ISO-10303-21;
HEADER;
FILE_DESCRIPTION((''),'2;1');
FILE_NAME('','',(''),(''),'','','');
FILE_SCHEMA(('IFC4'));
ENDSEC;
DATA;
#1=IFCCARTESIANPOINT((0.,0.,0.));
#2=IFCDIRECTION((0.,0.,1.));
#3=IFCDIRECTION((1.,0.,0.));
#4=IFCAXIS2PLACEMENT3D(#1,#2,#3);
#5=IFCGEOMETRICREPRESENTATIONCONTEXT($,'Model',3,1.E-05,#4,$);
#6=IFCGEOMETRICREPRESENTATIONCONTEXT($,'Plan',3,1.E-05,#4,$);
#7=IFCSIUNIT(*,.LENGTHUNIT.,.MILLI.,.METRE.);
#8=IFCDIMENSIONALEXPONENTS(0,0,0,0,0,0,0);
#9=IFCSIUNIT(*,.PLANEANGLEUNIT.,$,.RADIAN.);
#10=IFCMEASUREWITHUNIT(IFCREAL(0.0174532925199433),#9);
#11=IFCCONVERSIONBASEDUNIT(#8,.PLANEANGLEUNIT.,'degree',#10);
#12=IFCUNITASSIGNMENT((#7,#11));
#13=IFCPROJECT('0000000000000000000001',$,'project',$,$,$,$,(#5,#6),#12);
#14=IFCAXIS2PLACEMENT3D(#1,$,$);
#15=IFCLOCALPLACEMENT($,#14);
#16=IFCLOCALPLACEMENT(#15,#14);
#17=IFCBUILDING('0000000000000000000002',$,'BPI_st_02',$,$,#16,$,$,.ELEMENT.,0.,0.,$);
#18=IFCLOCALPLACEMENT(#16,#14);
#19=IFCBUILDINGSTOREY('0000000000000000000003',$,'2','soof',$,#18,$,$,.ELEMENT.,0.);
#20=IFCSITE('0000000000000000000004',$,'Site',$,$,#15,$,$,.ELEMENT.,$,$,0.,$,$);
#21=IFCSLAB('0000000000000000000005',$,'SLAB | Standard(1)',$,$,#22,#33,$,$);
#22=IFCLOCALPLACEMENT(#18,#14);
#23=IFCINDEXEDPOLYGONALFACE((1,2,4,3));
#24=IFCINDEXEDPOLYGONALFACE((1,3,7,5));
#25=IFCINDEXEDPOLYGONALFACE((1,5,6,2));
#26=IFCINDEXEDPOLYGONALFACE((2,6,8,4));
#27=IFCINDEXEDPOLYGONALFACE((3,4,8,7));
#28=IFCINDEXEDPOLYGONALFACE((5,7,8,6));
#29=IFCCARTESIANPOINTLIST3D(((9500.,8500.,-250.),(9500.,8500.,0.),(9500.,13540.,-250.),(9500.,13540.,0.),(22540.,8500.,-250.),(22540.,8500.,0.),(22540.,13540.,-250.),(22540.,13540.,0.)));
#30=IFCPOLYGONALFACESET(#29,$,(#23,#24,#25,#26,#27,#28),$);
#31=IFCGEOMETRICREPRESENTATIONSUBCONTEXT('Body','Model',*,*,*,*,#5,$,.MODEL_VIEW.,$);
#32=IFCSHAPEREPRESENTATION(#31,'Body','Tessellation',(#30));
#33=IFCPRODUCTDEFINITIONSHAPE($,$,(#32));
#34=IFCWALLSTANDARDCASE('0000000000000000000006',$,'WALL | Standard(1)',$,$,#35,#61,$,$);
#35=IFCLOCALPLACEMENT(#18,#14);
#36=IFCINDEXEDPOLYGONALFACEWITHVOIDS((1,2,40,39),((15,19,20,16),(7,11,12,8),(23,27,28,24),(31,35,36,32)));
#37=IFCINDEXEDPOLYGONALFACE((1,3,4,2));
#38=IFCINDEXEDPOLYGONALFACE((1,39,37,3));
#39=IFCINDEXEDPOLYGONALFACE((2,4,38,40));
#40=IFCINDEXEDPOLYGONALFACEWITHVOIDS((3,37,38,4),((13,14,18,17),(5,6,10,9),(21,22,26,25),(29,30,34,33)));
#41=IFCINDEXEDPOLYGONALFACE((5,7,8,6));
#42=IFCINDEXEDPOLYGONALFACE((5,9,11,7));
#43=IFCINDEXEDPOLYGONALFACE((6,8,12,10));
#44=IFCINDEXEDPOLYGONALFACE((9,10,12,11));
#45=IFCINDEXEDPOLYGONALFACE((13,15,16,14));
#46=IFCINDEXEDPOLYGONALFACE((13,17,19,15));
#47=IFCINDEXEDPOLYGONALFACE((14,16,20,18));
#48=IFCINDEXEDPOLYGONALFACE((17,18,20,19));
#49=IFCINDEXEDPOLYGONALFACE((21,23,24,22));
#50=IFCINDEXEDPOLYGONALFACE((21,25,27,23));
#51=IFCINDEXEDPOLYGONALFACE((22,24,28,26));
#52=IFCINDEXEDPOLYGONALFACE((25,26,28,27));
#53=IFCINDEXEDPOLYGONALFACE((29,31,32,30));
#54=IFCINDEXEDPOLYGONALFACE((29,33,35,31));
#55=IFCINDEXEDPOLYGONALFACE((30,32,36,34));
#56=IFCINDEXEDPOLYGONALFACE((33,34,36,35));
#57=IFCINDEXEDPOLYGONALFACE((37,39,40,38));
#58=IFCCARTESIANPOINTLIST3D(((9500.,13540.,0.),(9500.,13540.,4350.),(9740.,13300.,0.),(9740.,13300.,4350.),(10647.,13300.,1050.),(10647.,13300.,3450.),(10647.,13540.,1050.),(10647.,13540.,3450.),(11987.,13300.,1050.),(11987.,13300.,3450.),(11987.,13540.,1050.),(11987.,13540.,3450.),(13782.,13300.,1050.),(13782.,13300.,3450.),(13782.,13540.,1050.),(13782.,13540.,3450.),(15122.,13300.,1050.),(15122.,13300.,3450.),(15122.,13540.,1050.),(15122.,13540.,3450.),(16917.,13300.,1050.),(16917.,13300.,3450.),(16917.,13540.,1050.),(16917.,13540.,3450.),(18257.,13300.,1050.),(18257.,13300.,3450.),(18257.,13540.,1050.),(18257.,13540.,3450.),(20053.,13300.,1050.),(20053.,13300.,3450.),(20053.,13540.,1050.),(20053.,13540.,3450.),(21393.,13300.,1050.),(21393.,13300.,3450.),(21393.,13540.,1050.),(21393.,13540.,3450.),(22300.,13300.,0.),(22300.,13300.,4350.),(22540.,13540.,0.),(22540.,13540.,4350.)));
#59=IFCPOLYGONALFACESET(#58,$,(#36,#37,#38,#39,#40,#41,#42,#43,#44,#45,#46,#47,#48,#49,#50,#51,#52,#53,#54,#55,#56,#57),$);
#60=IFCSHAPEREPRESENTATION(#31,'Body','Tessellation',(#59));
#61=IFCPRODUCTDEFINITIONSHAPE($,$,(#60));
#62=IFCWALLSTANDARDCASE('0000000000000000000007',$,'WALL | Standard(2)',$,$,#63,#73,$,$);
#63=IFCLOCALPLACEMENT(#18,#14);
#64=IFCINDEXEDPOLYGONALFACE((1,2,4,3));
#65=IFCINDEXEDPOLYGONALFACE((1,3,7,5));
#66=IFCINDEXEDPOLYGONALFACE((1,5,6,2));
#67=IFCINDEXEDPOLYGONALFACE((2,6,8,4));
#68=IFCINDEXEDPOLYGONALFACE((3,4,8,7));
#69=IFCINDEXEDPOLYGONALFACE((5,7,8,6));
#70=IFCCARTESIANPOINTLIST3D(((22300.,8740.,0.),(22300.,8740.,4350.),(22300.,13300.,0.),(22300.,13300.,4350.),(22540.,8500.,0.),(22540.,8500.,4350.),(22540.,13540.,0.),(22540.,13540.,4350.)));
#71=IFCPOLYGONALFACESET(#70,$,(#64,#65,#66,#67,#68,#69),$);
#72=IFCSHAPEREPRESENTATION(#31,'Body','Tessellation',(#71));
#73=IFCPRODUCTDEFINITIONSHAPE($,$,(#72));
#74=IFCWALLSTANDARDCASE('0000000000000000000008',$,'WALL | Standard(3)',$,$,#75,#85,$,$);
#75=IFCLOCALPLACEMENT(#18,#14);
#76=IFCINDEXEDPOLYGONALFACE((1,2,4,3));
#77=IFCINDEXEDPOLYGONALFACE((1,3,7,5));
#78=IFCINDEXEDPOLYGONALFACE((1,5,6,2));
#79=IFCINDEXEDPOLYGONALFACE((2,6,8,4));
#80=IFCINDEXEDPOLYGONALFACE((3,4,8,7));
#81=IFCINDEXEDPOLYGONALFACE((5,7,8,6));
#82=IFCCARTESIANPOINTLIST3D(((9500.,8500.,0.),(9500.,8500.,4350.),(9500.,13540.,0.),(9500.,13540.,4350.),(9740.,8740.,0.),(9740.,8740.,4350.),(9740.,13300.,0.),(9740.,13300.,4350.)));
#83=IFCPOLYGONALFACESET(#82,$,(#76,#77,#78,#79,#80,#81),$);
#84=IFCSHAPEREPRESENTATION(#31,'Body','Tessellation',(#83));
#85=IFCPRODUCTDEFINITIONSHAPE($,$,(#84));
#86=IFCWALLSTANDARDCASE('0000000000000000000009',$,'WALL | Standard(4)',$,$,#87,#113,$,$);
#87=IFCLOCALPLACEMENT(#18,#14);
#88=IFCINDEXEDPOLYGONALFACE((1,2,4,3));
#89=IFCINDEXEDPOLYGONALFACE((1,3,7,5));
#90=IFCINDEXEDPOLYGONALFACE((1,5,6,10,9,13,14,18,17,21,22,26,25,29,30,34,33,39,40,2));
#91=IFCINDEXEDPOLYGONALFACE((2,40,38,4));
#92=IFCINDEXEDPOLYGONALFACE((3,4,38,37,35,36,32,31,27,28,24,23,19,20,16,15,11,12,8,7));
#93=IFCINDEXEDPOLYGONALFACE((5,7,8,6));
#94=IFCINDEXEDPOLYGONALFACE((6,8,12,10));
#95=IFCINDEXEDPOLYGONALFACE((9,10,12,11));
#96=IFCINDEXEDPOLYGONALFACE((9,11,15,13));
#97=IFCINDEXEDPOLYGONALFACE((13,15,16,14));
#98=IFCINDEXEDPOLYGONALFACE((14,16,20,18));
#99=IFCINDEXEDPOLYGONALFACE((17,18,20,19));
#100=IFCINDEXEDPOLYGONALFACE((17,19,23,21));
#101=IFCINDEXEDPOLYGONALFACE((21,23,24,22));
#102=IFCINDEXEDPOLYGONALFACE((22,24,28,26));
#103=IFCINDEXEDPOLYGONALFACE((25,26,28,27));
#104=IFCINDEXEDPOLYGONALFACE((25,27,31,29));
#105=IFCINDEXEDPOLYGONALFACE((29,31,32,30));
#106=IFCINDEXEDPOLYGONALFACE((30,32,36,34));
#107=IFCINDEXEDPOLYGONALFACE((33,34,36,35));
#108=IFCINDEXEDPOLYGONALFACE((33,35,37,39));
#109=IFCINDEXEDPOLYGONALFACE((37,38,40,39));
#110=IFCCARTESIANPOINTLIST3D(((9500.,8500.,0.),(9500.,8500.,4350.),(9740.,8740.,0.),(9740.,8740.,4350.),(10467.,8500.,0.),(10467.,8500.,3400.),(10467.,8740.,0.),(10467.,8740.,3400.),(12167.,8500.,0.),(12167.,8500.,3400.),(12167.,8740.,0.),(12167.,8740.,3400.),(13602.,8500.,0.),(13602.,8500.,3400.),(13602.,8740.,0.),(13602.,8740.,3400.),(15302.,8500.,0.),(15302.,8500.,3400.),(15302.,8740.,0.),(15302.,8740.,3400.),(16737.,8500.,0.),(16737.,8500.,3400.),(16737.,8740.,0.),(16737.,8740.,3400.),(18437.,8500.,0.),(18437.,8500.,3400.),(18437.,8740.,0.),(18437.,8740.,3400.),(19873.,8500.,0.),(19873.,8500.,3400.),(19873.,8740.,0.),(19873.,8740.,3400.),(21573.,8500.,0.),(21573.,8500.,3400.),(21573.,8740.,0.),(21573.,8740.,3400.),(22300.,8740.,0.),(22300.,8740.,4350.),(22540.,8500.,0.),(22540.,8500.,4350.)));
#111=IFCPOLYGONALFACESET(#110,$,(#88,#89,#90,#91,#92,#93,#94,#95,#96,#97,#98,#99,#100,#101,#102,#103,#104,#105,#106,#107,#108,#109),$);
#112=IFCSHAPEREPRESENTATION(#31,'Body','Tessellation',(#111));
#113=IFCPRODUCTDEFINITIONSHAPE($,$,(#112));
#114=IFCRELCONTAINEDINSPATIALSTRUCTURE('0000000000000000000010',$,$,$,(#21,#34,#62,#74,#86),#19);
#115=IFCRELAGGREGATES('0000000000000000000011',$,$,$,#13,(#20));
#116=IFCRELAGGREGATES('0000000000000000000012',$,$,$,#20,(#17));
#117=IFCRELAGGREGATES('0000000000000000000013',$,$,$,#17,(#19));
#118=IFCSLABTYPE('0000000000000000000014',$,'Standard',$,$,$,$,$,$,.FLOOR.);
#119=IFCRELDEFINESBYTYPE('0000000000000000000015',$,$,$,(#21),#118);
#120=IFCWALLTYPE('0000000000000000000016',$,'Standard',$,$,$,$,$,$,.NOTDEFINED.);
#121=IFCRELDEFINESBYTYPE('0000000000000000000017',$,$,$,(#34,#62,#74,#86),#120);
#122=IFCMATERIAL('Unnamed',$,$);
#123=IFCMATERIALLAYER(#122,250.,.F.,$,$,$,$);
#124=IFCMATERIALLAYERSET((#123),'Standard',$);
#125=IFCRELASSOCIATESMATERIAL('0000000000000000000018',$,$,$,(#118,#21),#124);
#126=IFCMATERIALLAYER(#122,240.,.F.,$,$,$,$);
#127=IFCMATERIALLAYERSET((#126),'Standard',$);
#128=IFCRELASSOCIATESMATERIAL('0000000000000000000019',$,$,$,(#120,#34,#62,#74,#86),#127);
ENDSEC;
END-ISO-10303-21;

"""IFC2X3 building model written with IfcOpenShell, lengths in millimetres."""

from ifc_helpers import new_model, entity, si_unit, converted_unit, frame, frame_2d, origin, origin_with_axes, origin_2d_with_axis, place, context, subcontext, project, spatial, polyline, segment, composite_curve, rectangle, outline, extrude, material, layer, layer_set, layer_usage, type_object, element, save


model = new_model("IFC2X3")

# Units and contexts
model_context = context("Model", 3, precision=1e-05, world=origin_with_axes())
plan_context = context("Plan", 3, precision=1e-05, world=origin_with_axes())
body_context = subcontext(model_context, "Body", "Model", "MODEL_VIEW")
ifc_project = project(units=[si_unit("LENGTHUNIT", "METRE", prefix="MILLI"), converted_unit("PLANEANGLEUNIT", "degree", entity("IfcReal", 0.0174532925199433), si_unit("PLANEANGLEUNIT", "RADIAN"), dimensions=[0, 0, 0, 0, 0, 0, 0])], contexts=[model_context, plan_context])

# Site, building, storey
site_placement = place(None, origin())
site = spatial("IfcSite", under=ifc_project, at=site_placement, Name="Site", CompositionType="ELEMENT", RefElevation=0.0)
building_placement = place(site_placement, origin())
building = spatial("IfcBuilding", under=site, at=building_placement, Name="BPI_st_02", CompositionType="ELEMENT", ElevationOfRefHeight=0.0, ElevationOfTerrain=0.0)
storey_placement = place(building_placement, origin())
storey = spatial("IfcBuildingStorey", under=building, at=storey_placement, Name="2", Description="soof", CompositionType="ELEMENT", Elevation=0.0)

# Slab
ifc_material = material(Name="Unnamed")
ifc_layer_1 = layer(ifc_material, 250.0, ventilated=False)
ifc_layer_set_1 = layer_set([ifc_layer_1], Name="Standard")
ifc_layer_usage_1 = layer_usage(ifc_layer_set_1, "AXIS3", "POSITIVE", 0.0)
slab_type = type_object("IfcSlabType", Name="Standard", PredefinedType="FLOOR", material=ifc_layer_set_1)
slab_placement = place(storey_placement, frame((22540.0, 13540.0, 0.0), z_axis=(0.0, 0.0, 1.0), x_axis=(-1.0, 0.0, 0.0)))
element("IfcSlab", 1, at=slab_placement, inside=storey, type_object=slab_type, material=ifc_layer_usage_1, Name="SLAB | Standard(1)", context=body_context, shape_type="SweptSolid", body=[
    extrude(rectangle(XDim=13040.0, YDim=5040.0, at=frame_2d((6520.0, 2520.0), x_axis=(1.0, 0.0))), frame((0.0, 0.0, -250.0)), (0.0, 0.0, 1.0), 250.0),
])

# Wall, openings
ifc_layer_2 = layer(ifc_material, 240.0, ventilated=False)
ifc_layer_set_2 = layer_set([ifc_layer_2], Name="Standard")
ifc_layer_usage_2 = layer_usage(ifc_layer_set_2, "AXIS2", "POSITIVE", -120.0)
wall_type = type_object("IfcWallType", Name="Standard", PredefinedType="NOTDEFINED", material=ifc_layer_set_2)
wall_1_placement = place(storey_placement, frame((9620.0, 13420.0, 0.0)))
wall_1 = element("IfcWallStandardCase", 2, at=wall_1_placement, inside=storey, type_object=wall_type, material=ifc_layer_usage_2, Name="WALL | Standard(1)", context=body_context, shape_type="SweptSolid", body=[
    extrude(outline(composite_curve([segment(polyline([(-120.0, 120.0), (120.0, -120.0)]), True, "CONTINUOUS"), segment(polyline([(120.0, -120.0), (12680.0, -120.0)]), True, "CONTINUOUS"), segment(polyline([(12680.0, -120.0), (12920.0, 120.0)]), True, "CONTINUOUS"), segment(polyline([(12920.0, 120.0), (-120.0, 120.0)]), True, "CONTINUOUS")], self_intersect=False)), origin(), (0.0, 0.0, 1.0), 4350.0),
])
opening_1_placement = place(wall_1_placement, frame((1027.0, 0.0, 1050.0)))
element("IfcOpeningElement", 3, at=opening_1_placement, cuts=wall_1, context=body_context, shape_type="SweptSolid", body=[
    extrude(rectangle(XDim=1340.0, YDim=2400.0, at=origin_2d_with_axis()), frame((670.0, 120.0, 1200.0), z_axis=(0.0, -1.0, 0.0), x_axis=(1.0, 0.0, 0.0)), (0.0, 0.0, 1.0), 240.0),
])
opening_2_placement = place(wall_1_placement, frame((4162.0, 0.0, 1050.0)))
element("IfcOpeningElement", 4, at=opening_2_placement, cuts=wall_1, context=body_context, shape_type="SweptSolid", body=[
    extrude(rectangle(XDim=1340.0, YDim=2400.0, at=origin_2d_with_axis()), frame((670.0, 120.0, 1200.0), z_axis=(0.0, -1.0, 0.0), x_axis=(1.0, 0.0, 0.0)), (0.0, 0.0, 1.0), 240.0),
])
opening_3_placement = place(wall_1_placement, frame((7297.0, 0.0, 1050.0)))
element("IfcOpeningElement", 5, at=opening_3_placement, cuts=wall_1, context=body_context, shape_type="SweptSolid", body=[
    extrude(rectangle(XDim=1340.0, YDim=2400.0, at=origin_2d_with_axis()), frame((670.0, 120.0, 1200.0), z_axis=(0.0, -1.0, 0.0), x_axis=(1.0, 0.0, 0.0)), (0.0, 0.0, 1.0), 240.0),
])
opening_4_placement = place(wall_1_placement, frame((10433.0, 0.0, 1050.0)))
element("IfcOpeningElement", 6, at=opening_4_placement, cuts=wall_1, context=body_context, shape_type="SweptSolid", body=[
    extrude(rectangle(XDim=1340.0, YDim=2400.0, at=origin_2d_with_axis()), frame((670.0, 120.0, 1200.0), z_axis=(0.0, -1.0, 0.0), x_axis=(1.0, 0.0, 0.0)), (0.0, 0.0, 1.0), 240.0),
])

# Walls
ifc_layer_usage_3 = layer_usage(ifc_layer_set_2, "AXIS2", "POSITIVE", -120.0)
wall_2_placement = place(storey_placement, frame((22420.0, 13420.0, 0.0), z_axis=(0.0, 0.0, 1.0), x_axis=(0.0, -1.0, 0.0)))
element("IfcWallStandardCase", 7, at=wall_2_placement, inside=storey, type_object=wall_type, material=ifc_layer_usage_3, Name="WALL | Standard(2)", context=body_context, shape_type="SweptSolid", body=[
    extrude(outline(composite_curve([segment(polyline([(-120.0, 120.0), (120.0, -120.0)]), True, "CONTINUOUS"), segment(polyline([(120.0, -120.0), (4680.0, -120.0)]), True, "CONTINUOUS"), segment(polyline([(4680.0, -120.0), (4920.0, 120.0)]), True, "CONTINUOUS"), segment(polyline([(4920.0, 120.0), (-120.0, 120.0)]), True, "CONTINUOUS")], self_intersect=False)), origin(), (0.0, 0.0, 1.0), 4350.0),
])
ifc_layer_usage_4 = layer_usage(ifc_layer_set_2, "AXIS2", "POSITIVE", -120.0)
wall_3_placement = place(storey_placement, frame((9620.0, 8620.0, 0.0), z_axis=(0.0, 0.0, 1.0), x_axis=(0.0, 1.0, 0.0)))
element("IfcWallStandardCase", 8, at=wall_3_placement, inside=storey, type_object=wall_type, material=ifc_layer_usage_4, Name="WALL | Standard(3)", context=body_context, shape_type="SweptSolid", body=[
    extrude(outline(composite_curve([segment(polyline([(-120.0, 120.0), (120.0, -120.0)]), True, "CONTINUOUS"), segment(polyline([(120.0, -120.0), (4680.0, -120.0)]), True, "CONTINUOUS"), segment(polyline([(4680.0, -120.0), (4920.0, 120.0)]), True, "CONTINUOUS"), segment(polyline([(4920.0, 120.0), (-120.0, 120.0)]), True, "CONTINUOUS")], self_intersect=False)), origin(), (0.0, 0.0, 1.0), 4350.0),
])

# Wall, openings
ifc_layer_usage_5 = layer_usage(ifc_layer_set_2, "AXIS2", "POSITIVE", -120.0)
wall_4_placement = place(storey_placement, frame((9620.0, 8620.0, 0.0)))
wall_4 = element("IfcWallStandardCase", 9, at=wall_4_placement, inside=storey, type_object=wall_type, material=ifc_layer_usage_5, Name="WALL | Standard(4)", context=body_context, shape_type="SweptSolid", body=[
    extrude(outline(composite_curve([segment(polyline([(120.0, 120.0), (-120.0, -120.0)]), True, "CONTINUOUS"), segment(polyline([(-120.0, -120.0), (12920.0, -120.0)]), True, "CONTINUOUS"), segment(polyline([(12920.0, -120.0), (12680.0, 120.0)]), True, "CONTINUOUS"), segment(polyline([(12680.0, 120.0), (120.0, 120.0)]), True, "CONTINUOUS")], self_intersect=False)), origin(), (0.0, 0.0, 1.0), 4350.0),
])
opening_5_placement = place(wall_4_placement, frame((847.0, 0.0, 0.0)))
element("IfcOpeningElement", 10, at=opening_5_placement, cuts=wall_4, context=body_context, shape_type="SweptSolid", body=[
    extrude(rectangle(XDim=1700.0, YDim=3400.0, at=origin_2d_with_axis()), frame((850.0, 120.0, 1700.0), z_axis=(0.0, -1.0, 0.0), x_axis=(1.0, 0.0, 0.0)), (0.0, 0.0, 1.0), 240.0),
])
opening_6_placement = place(wall_4_placement, frame((3982.0, 0.0, 0.0)))
element("IfcOpeningElement", 11, at=opening_6_placement, cuts=wall_4, context=body_context, shape_type="SweptSolid", body=[
    extrude(rectangle(XDim=1700.0, YDim=3400.0, at=origin_2d_with_axis()), frame((850.0, 120.0, 1700.0), z_axis=(0.0, -1.0, 0.0), x_axis=(1.0, 0.0, 0.0)), (0.0, 0.0, 1.0), 240.0),
])
opening_7_placement = place(wall_4_placement, frame((7117.0, 0.0, 0.0)))
element("IfcOpeningElement", 12, at=opening_7_placement, cuts=wall_4, context=body_context, shape_type="SweptSolid", body=[
    extrude(rectangle(XDim=1700.0, YDim=3400.0, at=origin_2d_with_axis()), frame((850.0, 120.0, 1700.0), z_axis=(0.0, -1.0, 0.0), x_axis=(1.0, 0.0, 0.0)), (0.0, 0.0, 1.0), 240.0),
])
opening_8_placement = place(wall_4_placement, frame((10253.0, 0.0, 0.0)))
element("IfcOpeningElement", 13, at=opening_8_placement, cuts=wall_4, context=body_context, shape_type="SweptSolid", body=[
    extrude(rectangle(XDim=1700.0, YDim=3400.0, at=origin_2d_with_axis()), frame((850.0, 120.0, 1700.0), z_axis=(0.0, -1.0, 0.0), x_axis=(1.0, 0.0, 0.0)), (0.0, 0.0, 1.0), 240.0),
])

save(model, "model.ifc")
